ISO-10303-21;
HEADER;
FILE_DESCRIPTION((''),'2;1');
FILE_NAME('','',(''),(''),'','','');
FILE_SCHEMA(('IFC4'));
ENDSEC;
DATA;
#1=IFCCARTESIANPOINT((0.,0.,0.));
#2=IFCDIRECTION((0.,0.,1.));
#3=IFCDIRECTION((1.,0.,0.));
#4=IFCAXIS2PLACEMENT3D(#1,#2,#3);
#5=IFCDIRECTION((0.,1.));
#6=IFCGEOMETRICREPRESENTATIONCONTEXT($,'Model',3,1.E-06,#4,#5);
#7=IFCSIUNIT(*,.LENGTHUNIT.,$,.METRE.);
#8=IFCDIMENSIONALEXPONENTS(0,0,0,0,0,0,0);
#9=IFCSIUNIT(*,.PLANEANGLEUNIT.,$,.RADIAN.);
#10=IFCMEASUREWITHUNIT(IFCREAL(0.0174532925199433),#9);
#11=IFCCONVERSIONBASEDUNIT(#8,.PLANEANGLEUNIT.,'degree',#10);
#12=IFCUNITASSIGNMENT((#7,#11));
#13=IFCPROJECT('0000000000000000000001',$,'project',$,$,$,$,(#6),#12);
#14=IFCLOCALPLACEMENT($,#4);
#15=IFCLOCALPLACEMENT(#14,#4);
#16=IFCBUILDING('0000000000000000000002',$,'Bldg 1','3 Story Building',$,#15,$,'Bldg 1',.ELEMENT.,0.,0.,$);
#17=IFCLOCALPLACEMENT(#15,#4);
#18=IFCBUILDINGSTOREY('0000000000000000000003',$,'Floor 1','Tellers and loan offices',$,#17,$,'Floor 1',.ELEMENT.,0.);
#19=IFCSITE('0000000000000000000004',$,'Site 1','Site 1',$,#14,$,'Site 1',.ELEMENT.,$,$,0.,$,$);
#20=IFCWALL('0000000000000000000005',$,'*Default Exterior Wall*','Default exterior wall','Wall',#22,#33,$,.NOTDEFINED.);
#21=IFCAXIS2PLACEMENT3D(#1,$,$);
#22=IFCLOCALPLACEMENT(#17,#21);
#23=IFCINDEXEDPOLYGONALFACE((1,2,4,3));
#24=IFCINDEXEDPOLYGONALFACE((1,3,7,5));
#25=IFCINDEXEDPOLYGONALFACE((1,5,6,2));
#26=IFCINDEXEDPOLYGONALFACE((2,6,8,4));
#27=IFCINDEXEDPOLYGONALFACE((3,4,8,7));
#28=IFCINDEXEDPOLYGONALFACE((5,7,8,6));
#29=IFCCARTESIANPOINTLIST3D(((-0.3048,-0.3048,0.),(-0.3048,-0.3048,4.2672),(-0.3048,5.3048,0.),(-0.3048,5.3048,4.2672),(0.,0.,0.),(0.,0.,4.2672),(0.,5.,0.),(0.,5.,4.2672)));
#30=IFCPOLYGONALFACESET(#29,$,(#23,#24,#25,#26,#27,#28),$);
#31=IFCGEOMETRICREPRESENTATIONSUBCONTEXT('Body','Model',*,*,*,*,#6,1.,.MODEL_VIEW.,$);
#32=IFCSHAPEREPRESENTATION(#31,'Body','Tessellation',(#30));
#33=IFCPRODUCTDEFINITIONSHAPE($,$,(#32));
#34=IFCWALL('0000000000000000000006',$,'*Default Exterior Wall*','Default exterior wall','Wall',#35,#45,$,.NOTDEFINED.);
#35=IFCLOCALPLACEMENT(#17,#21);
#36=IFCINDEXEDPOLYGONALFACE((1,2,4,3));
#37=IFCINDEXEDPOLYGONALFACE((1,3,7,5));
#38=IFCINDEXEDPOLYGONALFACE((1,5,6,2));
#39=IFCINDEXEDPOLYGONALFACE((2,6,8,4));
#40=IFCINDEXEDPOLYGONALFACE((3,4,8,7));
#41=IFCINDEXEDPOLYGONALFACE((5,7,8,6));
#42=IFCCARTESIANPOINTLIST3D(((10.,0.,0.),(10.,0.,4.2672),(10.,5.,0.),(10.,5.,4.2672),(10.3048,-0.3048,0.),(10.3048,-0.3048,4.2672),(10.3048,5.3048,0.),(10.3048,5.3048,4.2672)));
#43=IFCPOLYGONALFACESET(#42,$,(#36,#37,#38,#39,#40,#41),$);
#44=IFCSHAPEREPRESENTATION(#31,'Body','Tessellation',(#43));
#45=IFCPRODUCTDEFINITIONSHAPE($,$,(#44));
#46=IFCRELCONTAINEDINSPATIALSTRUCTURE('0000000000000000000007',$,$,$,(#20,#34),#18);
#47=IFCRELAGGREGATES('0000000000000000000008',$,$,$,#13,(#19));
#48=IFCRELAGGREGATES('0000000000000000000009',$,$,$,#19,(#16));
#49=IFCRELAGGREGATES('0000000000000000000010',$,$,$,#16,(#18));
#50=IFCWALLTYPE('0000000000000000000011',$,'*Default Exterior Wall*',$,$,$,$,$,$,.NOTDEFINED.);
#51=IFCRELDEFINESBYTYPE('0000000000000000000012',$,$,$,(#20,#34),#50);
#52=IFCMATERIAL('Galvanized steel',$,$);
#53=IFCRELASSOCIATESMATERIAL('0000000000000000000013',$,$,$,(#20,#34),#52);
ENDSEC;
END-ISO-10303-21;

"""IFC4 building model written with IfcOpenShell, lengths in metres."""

from ifc_helpers import new_model, entity, si_unit, converted_unit, direction, frame, origin_with_axes, place, context, subcontext, project, spatial, line, indexed_curve, outline, extrude, material, type_object, element, save


model = new_model("IFC4")

# Units and contexts
model_context = context("Model", 3, precision=1e-06, world=origin_with_axes(), true_north=direction((0.0, 1.0)))
body_context = subcontext(model_context, "Body", "Model", "MODEL_VIEW", scale=1.0)
ifc_project = project(units=[si_unit("LENGTHUNIT", "METRE"), converted_unit("PLANEANGLEUNIT", "degree", entity("IfcReal", 0.0174532925199433), si_unit("PLANEANGLEUNIT", "RADIAN"), dimensions=[0, 0, 0, 0, 0, 0, 0])], contexts=[model_context])

# Site, building, storey
site_placement = place(None, origin_with_axes())
site = spatial("IfcSite", under=ifc_project, at=site_placement, Name="Site 1", Description="Site 1", LongName="Site 1", CompositionType="ELEMENT", RefElevation=0.0)
building_placement = place(site_placement, origin_with_axes())
building = spatial("IfcBuilding", under=site, at=building_placement, Name="Bldg 1", Description="3 Story Building", LongName="Bldg 1", CompositionType="ELEMENT", ElevationOfRefHeight=0.0, ElevationOfTerrain=0.0)
storey_placement = place(building_placement, origin_with_axes())
storey = spatial("IfcBuildingStorey", under=building, at=storey_placement, Name="Floor 1", Description="Tellers and loan offices", LongName="Floor 1", CompositionType="ELEMENT", Elevation=0.0)

# Walls
ifc_material = material(Name="Galvanized steel")
wall_type = type_object("IfcWallType", Name="*Default Exterior Wall*", PredefinedType="NOTDEFINED")
wall_1_placement = place(storey_placement, frame((0.0, 0.0, 0.0), z_axis=(0.0, 0.0, 1.0), x_axis=(0.0, 1.0, 0.0)))
element("IfcWall", 1, at=wall_1_placement, inside=storey, type_object=wall_type, material=ifc_material, Name="*Default Exterior Wall*", Description="Default exterior wall", ObjectType="Wall", PredefinedType="NOTDEFINED", context=body_context, shape_type="SweptSolid", body=[
    extrude(outline(indexed_curve([(5.3048, 0.3048), (-0.3048, 0.3048), (0.0, 0.0), (5.0, 0.0)], segments=[line(1, 2, 3, 4, 1)], self_intersect=False)), origin_with_axes(), (0.0, 0.0, 1.0), 4.2672),
])
wall_2_placement = place(storey_placement, frame((10.0, 5.0, 0.0), z_axis=(0.0, 0.0, 1.0), x_axis=(0.0, -1.0, 0.0)))
element("IfcWall", 2, at=wall_2_placement, inside=storey, type_object=wall_type, material=ifc_material, Name="*Default Exterior Wall*", Description="Default exterior wall", ObjectType="Wall", PredefinedType="NOTDEFINED", context=body_context, shape_type="SweptSolid", body=[
    extrude(outline(indexed_curve([(5.3048, 0.3048), (-0.3048, 0.3048), (0.0, 0.0), (5.0, 0.0)], segments=[line(1, 2, 3, 4, 1)], self_intersect=False)), origin_with_axes(), (0.0, 0.0, 1.0), 4.2672),
])

save(model, "model.ifc")
